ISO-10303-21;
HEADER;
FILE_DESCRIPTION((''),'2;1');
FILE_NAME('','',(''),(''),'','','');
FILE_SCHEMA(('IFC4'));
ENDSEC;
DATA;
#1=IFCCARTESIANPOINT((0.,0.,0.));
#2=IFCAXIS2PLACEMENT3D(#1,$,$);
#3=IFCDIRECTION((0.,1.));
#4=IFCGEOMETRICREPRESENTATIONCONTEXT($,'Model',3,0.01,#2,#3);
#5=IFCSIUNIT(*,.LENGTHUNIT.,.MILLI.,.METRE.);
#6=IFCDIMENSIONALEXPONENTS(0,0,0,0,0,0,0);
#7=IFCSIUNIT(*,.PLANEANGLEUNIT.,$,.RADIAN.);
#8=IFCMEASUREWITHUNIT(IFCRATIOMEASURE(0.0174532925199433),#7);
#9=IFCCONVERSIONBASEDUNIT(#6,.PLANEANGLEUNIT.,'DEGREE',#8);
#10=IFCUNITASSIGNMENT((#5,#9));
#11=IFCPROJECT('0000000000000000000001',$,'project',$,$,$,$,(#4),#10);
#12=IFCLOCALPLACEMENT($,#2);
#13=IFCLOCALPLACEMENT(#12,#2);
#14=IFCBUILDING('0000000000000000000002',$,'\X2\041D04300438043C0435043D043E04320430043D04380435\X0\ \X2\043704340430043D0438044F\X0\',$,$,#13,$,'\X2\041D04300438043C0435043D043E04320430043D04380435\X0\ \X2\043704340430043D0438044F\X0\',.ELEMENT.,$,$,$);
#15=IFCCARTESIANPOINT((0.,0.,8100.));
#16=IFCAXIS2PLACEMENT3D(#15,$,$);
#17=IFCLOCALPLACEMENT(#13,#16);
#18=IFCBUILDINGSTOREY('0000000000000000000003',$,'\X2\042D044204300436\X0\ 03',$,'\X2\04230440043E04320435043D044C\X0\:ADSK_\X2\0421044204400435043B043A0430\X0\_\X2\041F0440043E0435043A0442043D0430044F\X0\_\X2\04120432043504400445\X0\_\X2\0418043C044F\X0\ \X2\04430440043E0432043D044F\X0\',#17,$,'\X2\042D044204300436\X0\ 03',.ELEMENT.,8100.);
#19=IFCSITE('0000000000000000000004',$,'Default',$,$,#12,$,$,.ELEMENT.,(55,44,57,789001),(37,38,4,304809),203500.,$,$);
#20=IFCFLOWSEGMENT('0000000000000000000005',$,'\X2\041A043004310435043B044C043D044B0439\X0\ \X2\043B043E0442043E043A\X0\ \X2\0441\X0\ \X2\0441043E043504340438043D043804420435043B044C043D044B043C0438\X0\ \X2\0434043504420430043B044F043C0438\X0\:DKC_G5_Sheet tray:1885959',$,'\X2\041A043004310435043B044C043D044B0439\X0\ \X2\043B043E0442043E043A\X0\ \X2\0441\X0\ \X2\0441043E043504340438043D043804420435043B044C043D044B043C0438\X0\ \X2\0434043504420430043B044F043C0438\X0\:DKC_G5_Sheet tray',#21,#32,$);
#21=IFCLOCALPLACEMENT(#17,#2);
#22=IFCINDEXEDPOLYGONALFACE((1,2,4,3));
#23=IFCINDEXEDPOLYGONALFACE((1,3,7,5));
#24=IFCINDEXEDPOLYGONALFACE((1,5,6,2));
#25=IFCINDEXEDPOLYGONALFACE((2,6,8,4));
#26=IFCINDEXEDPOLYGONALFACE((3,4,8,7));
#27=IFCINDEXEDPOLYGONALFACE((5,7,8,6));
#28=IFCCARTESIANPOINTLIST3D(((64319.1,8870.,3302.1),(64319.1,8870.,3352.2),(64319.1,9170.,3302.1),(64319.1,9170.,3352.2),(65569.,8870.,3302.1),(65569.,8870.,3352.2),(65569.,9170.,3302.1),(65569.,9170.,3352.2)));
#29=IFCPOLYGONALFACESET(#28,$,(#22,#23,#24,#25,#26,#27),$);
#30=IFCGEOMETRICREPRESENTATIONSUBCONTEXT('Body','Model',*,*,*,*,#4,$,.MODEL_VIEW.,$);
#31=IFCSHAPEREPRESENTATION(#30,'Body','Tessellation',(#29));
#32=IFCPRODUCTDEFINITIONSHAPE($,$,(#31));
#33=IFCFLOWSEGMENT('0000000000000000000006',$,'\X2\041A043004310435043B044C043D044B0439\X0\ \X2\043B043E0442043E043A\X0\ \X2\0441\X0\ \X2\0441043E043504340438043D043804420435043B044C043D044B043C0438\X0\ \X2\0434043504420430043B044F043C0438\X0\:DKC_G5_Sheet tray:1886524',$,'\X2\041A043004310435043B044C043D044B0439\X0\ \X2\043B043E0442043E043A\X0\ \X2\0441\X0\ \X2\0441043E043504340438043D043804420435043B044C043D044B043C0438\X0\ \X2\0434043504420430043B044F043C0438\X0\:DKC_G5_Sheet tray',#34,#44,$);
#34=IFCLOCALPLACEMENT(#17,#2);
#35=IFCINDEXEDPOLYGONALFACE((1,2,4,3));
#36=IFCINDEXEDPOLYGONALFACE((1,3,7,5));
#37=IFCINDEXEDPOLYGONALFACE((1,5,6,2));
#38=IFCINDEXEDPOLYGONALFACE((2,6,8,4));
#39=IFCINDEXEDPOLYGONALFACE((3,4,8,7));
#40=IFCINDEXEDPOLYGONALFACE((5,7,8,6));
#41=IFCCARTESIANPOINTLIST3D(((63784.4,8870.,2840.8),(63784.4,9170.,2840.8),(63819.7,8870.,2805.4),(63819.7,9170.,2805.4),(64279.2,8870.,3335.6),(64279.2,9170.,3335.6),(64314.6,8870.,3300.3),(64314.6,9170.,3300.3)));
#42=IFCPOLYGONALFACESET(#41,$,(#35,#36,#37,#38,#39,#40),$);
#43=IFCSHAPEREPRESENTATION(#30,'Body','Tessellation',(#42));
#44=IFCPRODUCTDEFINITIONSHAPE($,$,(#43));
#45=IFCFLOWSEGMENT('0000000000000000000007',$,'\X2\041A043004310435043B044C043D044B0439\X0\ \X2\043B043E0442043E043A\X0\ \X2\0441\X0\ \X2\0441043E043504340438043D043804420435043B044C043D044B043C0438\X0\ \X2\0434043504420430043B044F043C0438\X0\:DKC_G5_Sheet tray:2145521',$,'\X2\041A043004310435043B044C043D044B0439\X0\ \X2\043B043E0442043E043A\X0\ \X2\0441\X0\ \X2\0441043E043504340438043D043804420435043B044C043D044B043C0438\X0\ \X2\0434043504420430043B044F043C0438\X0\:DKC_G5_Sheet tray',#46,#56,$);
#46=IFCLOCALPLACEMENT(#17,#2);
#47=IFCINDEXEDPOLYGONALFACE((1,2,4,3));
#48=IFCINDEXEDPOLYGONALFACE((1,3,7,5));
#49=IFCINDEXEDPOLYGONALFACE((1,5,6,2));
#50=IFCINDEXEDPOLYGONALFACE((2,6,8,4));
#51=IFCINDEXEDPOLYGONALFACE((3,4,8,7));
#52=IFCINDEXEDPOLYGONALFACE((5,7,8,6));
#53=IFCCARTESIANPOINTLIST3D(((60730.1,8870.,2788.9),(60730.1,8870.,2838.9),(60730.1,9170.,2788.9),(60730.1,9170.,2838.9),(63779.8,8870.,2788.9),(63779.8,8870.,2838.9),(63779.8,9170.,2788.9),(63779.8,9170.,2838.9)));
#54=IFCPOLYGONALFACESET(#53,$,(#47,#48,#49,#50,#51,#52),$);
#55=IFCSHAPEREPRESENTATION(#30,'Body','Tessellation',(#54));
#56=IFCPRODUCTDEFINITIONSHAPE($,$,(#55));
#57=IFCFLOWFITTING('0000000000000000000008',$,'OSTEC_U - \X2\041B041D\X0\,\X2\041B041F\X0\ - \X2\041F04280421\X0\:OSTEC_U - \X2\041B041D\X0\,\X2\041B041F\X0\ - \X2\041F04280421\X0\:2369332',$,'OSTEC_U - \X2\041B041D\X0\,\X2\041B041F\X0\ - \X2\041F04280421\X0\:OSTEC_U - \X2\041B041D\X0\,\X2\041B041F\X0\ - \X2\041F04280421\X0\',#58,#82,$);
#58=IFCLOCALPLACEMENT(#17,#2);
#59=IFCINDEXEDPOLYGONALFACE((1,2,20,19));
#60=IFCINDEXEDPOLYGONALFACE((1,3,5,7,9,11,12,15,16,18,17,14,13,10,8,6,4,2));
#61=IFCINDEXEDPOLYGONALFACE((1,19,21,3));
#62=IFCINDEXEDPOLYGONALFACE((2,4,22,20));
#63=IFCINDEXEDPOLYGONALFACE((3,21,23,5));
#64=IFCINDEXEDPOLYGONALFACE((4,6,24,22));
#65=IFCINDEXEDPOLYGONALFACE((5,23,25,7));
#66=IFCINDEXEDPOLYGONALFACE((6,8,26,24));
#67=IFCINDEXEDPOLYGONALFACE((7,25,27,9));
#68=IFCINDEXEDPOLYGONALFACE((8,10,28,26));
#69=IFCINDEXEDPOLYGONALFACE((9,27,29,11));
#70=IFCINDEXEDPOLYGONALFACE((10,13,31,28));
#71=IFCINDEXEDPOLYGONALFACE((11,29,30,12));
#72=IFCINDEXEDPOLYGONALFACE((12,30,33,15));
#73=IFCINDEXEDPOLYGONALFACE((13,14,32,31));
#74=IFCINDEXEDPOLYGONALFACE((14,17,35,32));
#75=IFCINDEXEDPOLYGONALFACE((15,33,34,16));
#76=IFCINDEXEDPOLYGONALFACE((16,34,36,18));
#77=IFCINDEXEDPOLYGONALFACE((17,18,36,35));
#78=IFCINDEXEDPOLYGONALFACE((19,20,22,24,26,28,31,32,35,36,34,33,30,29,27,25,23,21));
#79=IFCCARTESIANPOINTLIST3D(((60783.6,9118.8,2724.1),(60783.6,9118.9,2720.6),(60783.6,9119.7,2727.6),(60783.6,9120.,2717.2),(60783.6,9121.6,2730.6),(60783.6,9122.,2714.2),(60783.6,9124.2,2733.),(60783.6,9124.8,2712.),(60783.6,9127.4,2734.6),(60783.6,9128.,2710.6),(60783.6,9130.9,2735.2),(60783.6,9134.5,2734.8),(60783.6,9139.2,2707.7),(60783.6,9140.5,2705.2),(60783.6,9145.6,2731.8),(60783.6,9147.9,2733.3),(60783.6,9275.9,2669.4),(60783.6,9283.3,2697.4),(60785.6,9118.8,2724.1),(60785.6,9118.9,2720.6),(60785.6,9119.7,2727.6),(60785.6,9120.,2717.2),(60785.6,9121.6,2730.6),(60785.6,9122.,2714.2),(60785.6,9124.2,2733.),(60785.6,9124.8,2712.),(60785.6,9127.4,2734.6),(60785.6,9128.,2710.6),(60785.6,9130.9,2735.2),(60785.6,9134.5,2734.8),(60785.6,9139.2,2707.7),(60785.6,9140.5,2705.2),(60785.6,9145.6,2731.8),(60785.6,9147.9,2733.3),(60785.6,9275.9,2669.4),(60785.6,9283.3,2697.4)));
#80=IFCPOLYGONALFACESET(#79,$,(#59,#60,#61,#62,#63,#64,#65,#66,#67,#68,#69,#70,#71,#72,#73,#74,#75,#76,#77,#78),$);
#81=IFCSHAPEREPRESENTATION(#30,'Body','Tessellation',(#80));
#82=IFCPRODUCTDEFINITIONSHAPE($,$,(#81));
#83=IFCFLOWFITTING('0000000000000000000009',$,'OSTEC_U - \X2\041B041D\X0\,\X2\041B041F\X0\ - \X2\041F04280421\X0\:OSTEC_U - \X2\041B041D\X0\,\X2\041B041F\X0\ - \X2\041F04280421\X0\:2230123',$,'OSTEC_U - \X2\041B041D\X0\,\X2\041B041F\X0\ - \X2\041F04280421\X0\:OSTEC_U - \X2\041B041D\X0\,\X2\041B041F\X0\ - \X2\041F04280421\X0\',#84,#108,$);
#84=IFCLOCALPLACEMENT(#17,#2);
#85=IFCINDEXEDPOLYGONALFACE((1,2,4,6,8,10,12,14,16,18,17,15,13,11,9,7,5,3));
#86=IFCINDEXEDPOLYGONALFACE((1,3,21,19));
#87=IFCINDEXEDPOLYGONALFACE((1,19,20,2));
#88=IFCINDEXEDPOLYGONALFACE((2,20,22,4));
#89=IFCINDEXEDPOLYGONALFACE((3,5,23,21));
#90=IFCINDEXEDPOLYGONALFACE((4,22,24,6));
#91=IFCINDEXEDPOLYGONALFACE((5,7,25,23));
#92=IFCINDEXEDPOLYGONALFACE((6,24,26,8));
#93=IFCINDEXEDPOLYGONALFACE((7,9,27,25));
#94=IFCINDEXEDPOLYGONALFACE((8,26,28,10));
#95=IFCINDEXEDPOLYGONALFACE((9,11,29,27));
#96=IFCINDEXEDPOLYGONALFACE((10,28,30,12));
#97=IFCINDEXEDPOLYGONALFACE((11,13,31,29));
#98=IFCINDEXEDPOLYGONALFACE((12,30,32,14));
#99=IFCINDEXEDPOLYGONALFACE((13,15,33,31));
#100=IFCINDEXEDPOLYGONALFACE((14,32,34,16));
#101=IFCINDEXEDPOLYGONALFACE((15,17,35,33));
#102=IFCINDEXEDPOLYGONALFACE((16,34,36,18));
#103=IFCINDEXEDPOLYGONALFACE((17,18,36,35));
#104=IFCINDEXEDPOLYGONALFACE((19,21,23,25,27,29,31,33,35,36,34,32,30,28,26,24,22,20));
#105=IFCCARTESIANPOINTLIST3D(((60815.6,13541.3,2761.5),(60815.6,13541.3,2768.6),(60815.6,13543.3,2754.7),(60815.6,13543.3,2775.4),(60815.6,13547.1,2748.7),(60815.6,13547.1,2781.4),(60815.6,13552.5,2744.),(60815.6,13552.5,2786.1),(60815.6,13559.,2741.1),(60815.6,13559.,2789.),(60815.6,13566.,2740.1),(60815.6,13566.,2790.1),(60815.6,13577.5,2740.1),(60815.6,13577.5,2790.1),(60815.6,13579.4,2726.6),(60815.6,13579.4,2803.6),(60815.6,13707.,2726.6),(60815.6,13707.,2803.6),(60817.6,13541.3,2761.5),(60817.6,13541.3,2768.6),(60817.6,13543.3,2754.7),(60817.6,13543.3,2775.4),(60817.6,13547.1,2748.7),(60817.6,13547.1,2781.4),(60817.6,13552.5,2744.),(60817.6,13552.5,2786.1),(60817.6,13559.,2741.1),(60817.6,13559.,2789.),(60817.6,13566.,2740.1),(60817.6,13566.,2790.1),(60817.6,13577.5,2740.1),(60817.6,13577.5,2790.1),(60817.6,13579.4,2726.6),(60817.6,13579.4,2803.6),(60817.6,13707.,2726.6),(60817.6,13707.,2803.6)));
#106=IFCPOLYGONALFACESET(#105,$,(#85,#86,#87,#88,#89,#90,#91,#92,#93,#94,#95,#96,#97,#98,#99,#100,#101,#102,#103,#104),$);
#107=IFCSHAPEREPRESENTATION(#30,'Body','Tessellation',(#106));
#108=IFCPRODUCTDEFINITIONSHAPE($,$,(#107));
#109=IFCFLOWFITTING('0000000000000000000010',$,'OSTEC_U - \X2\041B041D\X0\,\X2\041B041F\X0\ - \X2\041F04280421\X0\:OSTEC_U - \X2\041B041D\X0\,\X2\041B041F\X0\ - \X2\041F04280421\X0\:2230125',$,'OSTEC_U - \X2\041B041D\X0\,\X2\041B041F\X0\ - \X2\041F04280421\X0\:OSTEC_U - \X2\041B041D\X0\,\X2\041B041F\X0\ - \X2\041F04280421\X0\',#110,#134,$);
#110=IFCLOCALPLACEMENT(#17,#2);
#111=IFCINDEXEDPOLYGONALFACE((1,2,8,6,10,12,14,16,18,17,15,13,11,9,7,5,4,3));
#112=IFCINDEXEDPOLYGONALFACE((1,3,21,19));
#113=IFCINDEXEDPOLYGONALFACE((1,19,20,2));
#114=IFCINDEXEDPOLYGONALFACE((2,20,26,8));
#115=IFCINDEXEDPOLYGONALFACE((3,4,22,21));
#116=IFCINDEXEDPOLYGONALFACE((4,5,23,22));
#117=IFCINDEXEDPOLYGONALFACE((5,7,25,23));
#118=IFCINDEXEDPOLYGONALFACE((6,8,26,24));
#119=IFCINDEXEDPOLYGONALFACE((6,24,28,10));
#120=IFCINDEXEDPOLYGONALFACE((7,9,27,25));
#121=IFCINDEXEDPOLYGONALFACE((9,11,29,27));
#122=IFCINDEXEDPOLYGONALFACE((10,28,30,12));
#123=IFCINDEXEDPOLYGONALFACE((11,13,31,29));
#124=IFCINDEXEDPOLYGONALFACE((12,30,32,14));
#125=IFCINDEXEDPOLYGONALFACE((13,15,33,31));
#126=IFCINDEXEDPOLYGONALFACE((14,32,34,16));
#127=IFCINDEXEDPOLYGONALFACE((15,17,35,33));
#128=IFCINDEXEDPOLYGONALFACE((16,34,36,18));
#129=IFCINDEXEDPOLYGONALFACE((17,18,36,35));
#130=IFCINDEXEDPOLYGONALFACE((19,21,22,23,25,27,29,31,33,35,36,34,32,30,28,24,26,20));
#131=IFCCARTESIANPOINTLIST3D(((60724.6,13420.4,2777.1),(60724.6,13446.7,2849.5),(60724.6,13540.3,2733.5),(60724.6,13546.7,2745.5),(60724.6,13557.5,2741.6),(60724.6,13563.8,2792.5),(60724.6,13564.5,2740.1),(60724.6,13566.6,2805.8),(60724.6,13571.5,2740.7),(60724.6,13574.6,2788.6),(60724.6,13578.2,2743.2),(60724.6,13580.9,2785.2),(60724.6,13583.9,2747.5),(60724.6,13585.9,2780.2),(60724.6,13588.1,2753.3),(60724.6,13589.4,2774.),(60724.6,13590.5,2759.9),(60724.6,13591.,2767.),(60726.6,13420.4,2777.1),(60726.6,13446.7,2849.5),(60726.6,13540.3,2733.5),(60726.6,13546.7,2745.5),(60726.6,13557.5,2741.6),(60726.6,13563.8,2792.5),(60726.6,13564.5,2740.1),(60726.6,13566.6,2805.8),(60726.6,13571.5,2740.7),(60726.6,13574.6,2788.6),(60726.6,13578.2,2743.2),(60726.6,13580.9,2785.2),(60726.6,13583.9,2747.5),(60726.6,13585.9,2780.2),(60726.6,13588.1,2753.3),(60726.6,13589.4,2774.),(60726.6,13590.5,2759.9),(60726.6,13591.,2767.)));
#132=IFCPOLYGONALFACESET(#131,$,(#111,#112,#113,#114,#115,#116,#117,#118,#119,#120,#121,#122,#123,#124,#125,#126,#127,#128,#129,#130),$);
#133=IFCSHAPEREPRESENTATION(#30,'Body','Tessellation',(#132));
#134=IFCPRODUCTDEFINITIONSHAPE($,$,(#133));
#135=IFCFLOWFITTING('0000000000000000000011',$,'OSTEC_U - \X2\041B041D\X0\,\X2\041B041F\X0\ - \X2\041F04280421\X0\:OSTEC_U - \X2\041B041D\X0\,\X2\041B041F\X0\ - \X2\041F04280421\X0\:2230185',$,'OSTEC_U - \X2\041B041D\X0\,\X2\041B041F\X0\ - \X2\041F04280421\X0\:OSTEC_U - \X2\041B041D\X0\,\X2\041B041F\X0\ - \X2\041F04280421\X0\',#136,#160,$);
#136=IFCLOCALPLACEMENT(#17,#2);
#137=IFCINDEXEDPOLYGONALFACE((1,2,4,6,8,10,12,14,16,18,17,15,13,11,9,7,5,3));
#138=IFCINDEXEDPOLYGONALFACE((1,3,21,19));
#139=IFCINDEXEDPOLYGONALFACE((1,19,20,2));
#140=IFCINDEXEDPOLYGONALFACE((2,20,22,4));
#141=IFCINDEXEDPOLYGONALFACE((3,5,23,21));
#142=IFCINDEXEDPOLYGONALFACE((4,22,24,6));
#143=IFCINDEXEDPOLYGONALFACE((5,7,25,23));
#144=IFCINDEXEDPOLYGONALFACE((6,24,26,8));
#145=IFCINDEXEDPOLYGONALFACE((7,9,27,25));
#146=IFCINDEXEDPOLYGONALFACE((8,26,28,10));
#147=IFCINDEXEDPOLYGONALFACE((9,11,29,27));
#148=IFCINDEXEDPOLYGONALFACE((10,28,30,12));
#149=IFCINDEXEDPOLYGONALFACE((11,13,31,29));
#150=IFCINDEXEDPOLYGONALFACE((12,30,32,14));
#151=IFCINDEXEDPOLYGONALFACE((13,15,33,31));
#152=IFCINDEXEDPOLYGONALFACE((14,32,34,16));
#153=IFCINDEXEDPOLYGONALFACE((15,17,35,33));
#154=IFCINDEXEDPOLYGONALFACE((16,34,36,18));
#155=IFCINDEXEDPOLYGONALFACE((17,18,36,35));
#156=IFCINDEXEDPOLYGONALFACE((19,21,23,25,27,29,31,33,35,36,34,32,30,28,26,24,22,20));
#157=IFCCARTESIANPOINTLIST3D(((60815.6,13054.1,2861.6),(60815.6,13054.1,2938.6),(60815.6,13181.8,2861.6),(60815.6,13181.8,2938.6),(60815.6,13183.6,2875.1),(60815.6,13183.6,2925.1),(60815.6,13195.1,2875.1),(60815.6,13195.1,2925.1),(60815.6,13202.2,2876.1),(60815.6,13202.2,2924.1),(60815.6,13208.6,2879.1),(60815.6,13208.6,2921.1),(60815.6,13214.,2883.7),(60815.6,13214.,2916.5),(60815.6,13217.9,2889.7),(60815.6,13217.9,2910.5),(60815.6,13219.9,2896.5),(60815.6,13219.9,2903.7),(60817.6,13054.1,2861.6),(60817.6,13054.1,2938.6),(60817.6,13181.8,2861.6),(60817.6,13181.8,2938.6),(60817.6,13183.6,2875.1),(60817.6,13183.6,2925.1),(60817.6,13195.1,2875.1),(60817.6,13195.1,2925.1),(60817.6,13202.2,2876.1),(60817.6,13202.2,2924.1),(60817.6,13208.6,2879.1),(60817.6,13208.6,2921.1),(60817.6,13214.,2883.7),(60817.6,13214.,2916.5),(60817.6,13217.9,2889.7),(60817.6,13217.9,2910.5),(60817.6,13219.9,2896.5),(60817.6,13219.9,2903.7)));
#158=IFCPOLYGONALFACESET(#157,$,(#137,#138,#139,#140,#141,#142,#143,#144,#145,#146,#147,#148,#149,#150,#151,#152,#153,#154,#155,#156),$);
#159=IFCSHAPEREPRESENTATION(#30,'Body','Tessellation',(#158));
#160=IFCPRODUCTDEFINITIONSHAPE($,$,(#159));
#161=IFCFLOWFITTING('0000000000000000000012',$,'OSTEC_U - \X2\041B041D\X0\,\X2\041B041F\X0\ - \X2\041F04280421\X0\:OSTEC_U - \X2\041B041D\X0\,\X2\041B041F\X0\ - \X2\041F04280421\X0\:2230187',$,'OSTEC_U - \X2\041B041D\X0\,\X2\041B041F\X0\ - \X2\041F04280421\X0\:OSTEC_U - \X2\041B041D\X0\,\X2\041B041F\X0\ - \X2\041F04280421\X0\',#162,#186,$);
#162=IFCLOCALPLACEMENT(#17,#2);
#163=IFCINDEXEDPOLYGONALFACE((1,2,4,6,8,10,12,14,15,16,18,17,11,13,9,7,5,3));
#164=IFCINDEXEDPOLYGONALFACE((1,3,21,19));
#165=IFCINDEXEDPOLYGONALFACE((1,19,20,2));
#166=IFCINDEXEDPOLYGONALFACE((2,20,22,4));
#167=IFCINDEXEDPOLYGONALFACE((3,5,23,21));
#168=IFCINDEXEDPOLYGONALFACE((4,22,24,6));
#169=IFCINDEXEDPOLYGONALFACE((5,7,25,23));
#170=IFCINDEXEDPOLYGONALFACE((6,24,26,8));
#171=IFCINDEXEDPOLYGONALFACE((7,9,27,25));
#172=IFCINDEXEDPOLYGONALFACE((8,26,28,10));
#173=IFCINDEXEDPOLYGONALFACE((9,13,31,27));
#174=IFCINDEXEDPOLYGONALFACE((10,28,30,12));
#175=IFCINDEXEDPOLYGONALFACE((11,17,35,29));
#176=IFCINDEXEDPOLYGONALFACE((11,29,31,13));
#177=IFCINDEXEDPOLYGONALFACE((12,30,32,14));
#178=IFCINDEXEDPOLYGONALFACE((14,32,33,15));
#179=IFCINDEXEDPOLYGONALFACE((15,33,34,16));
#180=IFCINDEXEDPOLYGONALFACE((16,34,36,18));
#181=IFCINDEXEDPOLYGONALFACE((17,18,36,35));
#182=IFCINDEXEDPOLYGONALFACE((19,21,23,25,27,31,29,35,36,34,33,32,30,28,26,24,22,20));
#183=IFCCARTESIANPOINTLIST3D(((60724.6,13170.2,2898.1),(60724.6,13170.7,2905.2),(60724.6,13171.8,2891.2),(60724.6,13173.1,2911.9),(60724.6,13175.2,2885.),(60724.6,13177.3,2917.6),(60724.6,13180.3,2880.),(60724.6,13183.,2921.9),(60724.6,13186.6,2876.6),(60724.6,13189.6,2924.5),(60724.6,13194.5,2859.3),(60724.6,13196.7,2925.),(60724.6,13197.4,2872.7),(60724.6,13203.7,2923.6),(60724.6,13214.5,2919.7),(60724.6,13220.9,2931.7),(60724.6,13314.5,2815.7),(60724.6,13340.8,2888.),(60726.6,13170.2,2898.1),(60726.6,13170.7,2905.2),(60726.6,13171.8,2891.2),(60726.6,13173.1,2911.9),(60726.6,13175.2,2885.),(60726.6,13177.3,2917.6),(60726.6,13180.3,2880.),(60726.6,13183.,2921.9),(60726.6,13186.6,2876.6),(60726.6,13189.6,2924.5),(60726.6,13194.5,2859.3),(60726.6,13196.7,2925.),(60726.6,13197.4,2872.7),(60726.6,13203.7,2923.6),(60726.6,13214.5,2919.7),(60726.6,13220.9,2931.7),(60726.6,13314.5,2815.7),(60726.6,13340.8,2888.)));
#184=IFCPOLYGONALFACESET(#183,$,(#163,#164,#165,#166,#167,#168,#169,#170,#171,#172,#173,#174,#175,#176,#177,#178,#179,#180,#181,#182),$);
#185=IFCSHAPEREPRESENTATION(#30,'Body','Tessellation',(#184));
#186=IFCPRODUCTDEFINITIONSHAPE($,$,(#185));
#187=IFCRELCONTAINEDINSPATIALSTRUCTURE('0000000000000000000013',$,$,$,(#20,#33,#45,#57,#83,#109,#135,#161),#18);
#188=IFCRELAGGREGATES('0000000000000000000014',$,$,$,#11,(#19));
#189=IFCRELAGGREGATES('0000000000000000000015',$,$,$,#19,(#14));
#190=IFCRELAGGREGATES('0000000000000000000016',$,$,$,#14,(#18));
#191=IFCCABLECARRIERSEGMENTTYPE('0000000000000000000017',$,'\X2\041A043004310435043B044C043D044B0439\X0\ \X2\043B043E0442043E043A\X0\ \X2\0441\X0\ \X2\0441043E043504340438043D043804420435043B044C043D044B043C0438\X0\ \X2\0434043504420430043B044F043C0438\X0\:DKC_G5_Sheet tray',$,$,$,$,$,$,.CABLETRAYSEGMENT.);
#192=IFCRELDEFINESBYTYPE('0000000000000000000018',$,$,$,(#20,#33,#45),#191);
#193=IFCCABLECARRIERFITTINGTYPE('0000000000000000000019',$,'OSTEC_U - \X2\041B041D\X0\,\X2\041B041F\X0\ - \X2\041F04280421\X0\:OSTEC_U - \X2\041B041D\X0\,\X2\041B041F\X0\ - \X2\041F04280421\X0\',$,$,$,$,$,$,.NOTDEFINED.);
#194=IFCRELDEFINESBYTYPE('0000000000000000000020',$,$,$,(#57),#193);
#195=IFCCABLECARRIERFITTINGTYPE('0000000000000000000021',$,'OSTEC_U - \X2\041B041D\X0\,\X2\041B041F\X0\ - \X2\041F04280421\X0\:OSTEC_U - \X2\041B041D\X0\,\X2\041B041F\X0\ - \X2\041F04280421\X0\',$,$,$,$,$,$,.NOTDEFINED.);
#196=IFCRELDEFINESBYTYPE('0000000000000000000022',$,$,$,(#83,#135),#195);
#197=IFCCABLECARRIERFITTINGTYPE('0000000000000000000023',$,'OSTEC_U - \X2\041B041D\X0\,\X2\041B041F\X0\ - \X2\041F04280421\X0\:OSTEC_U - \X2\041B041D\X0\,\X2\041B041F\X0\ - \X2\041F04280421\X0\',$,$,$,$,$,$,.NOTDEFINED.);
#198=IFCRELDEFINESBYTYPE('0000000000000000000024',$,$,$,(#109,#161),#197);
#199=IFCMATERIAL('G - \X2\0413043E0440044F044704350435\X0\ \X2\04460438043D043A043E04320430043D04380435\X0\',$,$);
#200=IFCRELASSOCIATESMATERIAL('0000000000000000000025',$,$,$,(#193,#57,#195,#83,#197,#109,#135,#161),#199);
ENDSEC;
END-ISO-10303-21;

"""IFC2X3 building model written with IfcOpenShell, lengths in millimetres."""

from ifc_helpers import new_model, entity, si_unit, converted_unit, direction, frame, frame_2d, origin, origin_2d_with_axis, place, context, subcontext, project, spatial, polyline, circle_curve, parameter, trimmed, segment, composite_curve, rectangle, outline, extrude, source, transform, mapped, material, type_object, type_shapes, element, save


model = new_model("IFC2X3")

# Units and contexts
model_context = context("Model", 3, precision=0.01, world=origin(), true_north=direction((0.0, 1.0)))
body_context = subcontext(model_context, "Body", "Model", "MODEL_VIEW")
ifc_project = project(units=[si_unit("LENGTHUNIT", "METRE", prefix="MILLI"), converted_unit("PLANEANGLEUNIT", "DEGREE", entity("IfcRatioMeasure", 0.0174532925199433), si_unit("PLANEANGLEUNIT", "RADIAN"), dimensions=[0, 0, 0, 0, 0, 0, 0])], contexts=[model_context])

# Site, building, storey
site_placement = place(None, origin())
site = spatial("IfcSite", under=ifc_project, at=site_placement, Name="Default", CompositionType="ELEMENT", RefLatitude=(55, 44, 57, 789001), RefLongitude=(37, 38, 4, 304809), RefElevation=203500.0)
building_placement = place(site_placement, origin())
building = spatial("IfcBuilding", under=site, at=building_placement, Name="Наименование здания", LongName="Наименование здания", CompositionType="ELEMENT")
storey_placement = place(building_placement, frame((0.0, 0.0, 8100.0)))
storey = spatial("IfcBuildingStorey", under=building, at=storey_placement, Name="Этаж 03", ObjectType="Уровень:ADSK_Стрелка_Проектная_Вверх_Имя уровня", LongName="Этаж 03", CompositionType="ELEMENT", Elevation=8100.0)

# Flow segments
cable_carrier_segment_type = type_object("IfcCableCarrierSegmentType", Name="Кабельный лоток с соединительными деталями:DKC_G5_Sheet tray", PredefinedType="CABLETRAYSEGMENT")
flow_segment_1_placement = place(storey_placement, frame((64319.1, 8870.0, 3302.2)))
element("IfcFlowSegment", 1, at=flow_segment_1_placement, inside=storey, type_object=cable_carrier_segment_type, Name="Кабельный лоток с соединительными деталями:DKC_G5_Sheet tray:1885959", ObjectType="Кабельный лоток с соединительными деталями:DKC_G5_Sheet tray", context=body_context, shape_type="SweptSolid", body=[
    extrude(rectangle(XDim=1249.9, YDim=300.0, at=origin_2d_with_axis()), frame((624.9, 150.0, 0.0), z_axis=(0.0, 0.0, 1.0), x_axis=(-1.0, 0.0, 0.0)), (0.0, 0.0, 1.0), 50.0),
])
flow_segment_2_placement = place(storey_placement, frame((63784.4, 8870.0, 2805.4)))
element("IfcFlowSegment", 2, at=flow_segment_2_placement, inside=storey, type_object=cable_carrier_segment_type, Name="Кабельный лоток с соединительными деталями:DKC_G5_Sheet tray:1886524", ObjectType="Кабельный лоток с соединительными деталями:DKC_G5_Sheet tray", context=body_context, shape_type="SweptSolid", body=[
    extrude(rectangle(XDim=50.0, YDim=300.0, at=origin_2d_with_axis()), frame((17.7, 150.0, 17.7), z_axis=(0.707107, 0.0, 0.707107), x_axis=(-0.707107, 0.0, 0.707107)), (0.0, 0.0, 1.0), 699.8),
])
flow_segment_3_placement = place(storey_placement, frame((60730.1, 8870.0, 2788.9)))
element("IfcFlowSegment", 3, at=flow_segment_3_placement, inside=storey, type_object=cable_carrier_segment_type, Name="Кабельный лоток с соединительными деталями:DKC_G5_Sheet tray:2145521", ObjectType="Кабельный лоток с соединительными деталями:DKC_G5_Sheet tray", context=body_context, shape_type="SweptSolid", body=[
    extrude(rectangle(XDim=3049.7, YDim=300.0, at=origin_2d_with_axis()), frame((1524.9, 150.0, 0.0)), (0.0, 0.0, 1.0), 50.0),
])

# Flow fittings
ifc_material_1 = material(Name="G - Горячее цинкование")
cable_carrier_fitting_type_1 = type_object("IfcCableCarrierFittingType", Name="OSTEC_U - ЛН,ЛП - ПШС:OSTEC_U - ЛН,ЛП - ПШС", PredefinedType="NOTDEFINED", material=ifc_material_1)
shared_shape_1 = source(origin(), body_context, "Body", "SweptSolid", [
    extrude(outline(composite_curve([segment(trimmed(circle_curve(frame_2d((-44.6, 0.0), x_axis=(1.0, 0.0)), 12.5), [parameter(90.0)], [parameter(270.0)], True, "PARAMETER"), True, "CONTINUOUS"), segment(polyline([(-44.6, -12.5), (-33.1, -12.5)]), True, "CONTINUOUS"), segment(polyline([(-33.1, -12.5), (-31.2, -14.5)]), True, "CONTINUOUS"), segment(polyline([(-31.2, -14.5), (108.9, -14.5)]), True, "CONTINUOUS"), segment(polyline([(108.9, -14.5), (108.9, 14.5)]), True, "CONTINUOUS"), segment(polyline([(108.9, 14.5), (-31.2, 14.5)]), True, "CONTINUOUS"), segment(polyline([(-31.2, 14.5), (-33.1, 12.5)]), True, "CONTINUOUS"), segment(polyline([(-33.1, 12.5), (-44.6, 12.5)]), True, "CONTINUOUS")], self_intersect=False)), frame((44.6, 0.0, 0.0)), (0.0, 0.0, 1.0), 2.0),
])
type_shapes(cable_carrier_fitting_type_1, [shared_shape_1])
for number, where, z_axis, x_axis, name in (
    (4, (60783.6, 9131.2, 2722.7), (1.0, 0.0, 0.0), (0.0, 0.966668, -0.256034), "OSTEC_U - ЛН,ЛП - ПШС:OSTEC_U - ЛН,ЛП - ПШС:2369332"),
):
    element("IfcFlowFitting", number, at=place(storey_placement, frame(where, z_axis=z_axis, x_axis=x_axis)), inside=storey, type_object=cable_carrier_fitting_type_1, material=ifc_material_1, Name=name, ObjectType="OSTEC_U - ЛН,ЛП - ПШС:OSTEC_U - ЛН,ЛП - ПШС", context=body_context, shape_type="MappedRepresentation", body=[
        mapped(shared_shape_1, transform((0.0, 0.0, 0.0), scale=1.0)),
    ])
cable_carrier_fitting_type_2 = type_object("IfcCableCarrierFittingType", Name="OSTEC_U - ЛН,ЛП - ПШС:OSTEC_U - ЛН,ЛП - ПШС", PredefinedType="NOTDEFINED", material=ifc_material_1)
shared_shape_2 = source(origin(), body_context, "Body", "SweptSolid", [
    extrude(outline(composite_curve([segment(trimmed(circle_curve(frame_2d((-41.5, 0.0), x_axis=(1.0, 0.0)), 25.0), [parameter(90.0)], [parameter(270.0)], True, "PARAMETER"), True, "CONTINUOUS"), segment(polyline([(-41.5, -25.0), (-30.0, -25.0)]), True, "CONTINUOUS"), segment(polyline([(-30.0, -25.0), (-28.1, -38.5)]), True, "CONTINUOUS"), segment(polyline([(-28.1, -38.5), (99.5, -38.5)]), True, "CONTINUOUS"), segment(polyline([(99.5, -38.5), (99.5, 38.5)]), True, "CONTINUOUS"), segment(polyline([(99.5, 38.5), (-28.1, 38.5)]), True, "CONTINUOUS"), segment(polyline([(-28.1, 38.5), (-30.0, 25.0)]), True, "CONTINUOUS"), segment(polyline([(-30.0, 25.0), (-41.5, 25.0)]), True, "CONTINUOUS")], self_intersect=False)), frame((41.5, 0.0, 0.0), z_axis=(0.0, 0.0, -1.0), x_axis=(1.0, 0.0, 0.0)), (0.0, 0.0, -1.0), 2.0),
])
type_shapes(cable_carrier_fitting_type_2, [shared_shape_2])
flow_fitting_1_placement = place(storey_placement, frame((60815.6, 13566.0, 2765.1), z_axis=(1.0, 0.0, 0.0), x_axis=(0.0, 1.0, 0.000034)))
element("IfcFlowFitting", 5, at=flow_fitting_1_placement, inside=storey, type_object=cable_carrier_fitting_type_2, material=ifc_material_1, Name="OSTEC_U - ЛН,ЛП - ПШС:OSTEC_U - ЛН,ЛП - ПШС:2230123", ObjectType="OSTEC_U - ЛН,ЛП - ПШС:OSTEC_U - ЛН,ЛП - ПШС", context=body_context, shape_type="MappedRepresentation", body=[
    mapped(shared_shape_2, transform((0.0, 0.0, 0.0), scale=1.0)),
])
cable_carrier_fitting_type_3 = type_object("IfcCableCarrierFittingType", Name="OSTEC_U - ЛН,ЛП - ПШС:OSTEC_U - ЛН,ЛП - ПШС", PredefinedType="NOTDEFINED", material=ifc_material_1)
type_shapes(cable_carrier_fitting_type_3, [shared_shape_2])
flow_fitting_2_placement = place(storey_placement, frame((60726.7, 13566.0, 2765.1), z_axis=(-1.0, 0.0, 0.0), x_axis=(0.0, -0.939662, 0.342104)))
element("IfcFlowFitting", 6, at=flow_fitting_2_placement, inside=storey, type_object=cable_carrier_fitting_type_3, material=ifc_material_1, Name="OSTEC_U - ЛН,ЛП - ПШС:OSTEC_U - ЛН,ЛП - ПШС:2230125", ObjectType="OSTEC_U - ЛН,ЛП - ПШС:OSTEC_U - ЛН,ЛП - ПШС", context=body_context, shape_type="MappedRepresentation", body=[
    mapped(shared_shape_2, transform((0.0, 0.0, 0.0), scale=1.0)),
])
flow_fitting_3_placement = place(storey_placement, frame((60815.6, 13195.1, 2900.1), z_axis=(1.0, 0.0, 0.0), x_axis=(0.0, -1.0, 0.0)))
element("IfcFlowFitting", 7, at=flow_fitting_3_placement, inside=storey, type_object=cable_carrier_fitting_type_2, material=ifc_material_1, Name="OSTEC_U - ЛН,ЛП - ПШС:OSTEC_U - ЛН,ЛП - ПШС:2230185", ObjectType="OSTEC_U - ЛН,ЛП - ПШС:OSTEC_U - ЛН,ЛП - ПШС", context=body_context, shape_type="MappedRepresentation", body=[
    mapped(shared_shape_2, transform((0.0, 0.0, 0.0), scale=1.0)),
])
for number, where, z_axis, x_axis, name in (
    (8, (60726.7, 13195.1, 2900.1), (-1.0, 0.0, 0.0), (0.0, 0.939662, -0.342104), "OSTEC_U - ЛН,ЛП - ПШС:OSTEC_U - ЛН,ЛП - ПШС:2230187"),
):
    element("IfcFlowFitting", number, at=place(storey_placement, frame(where, z_axis=z_axis, x_axis=x_axis)), inside=storey, type_object=cable_carrier_fitting_type_3, material=ifc_material_1, Name=name, ObjectType="OSTEC_U - ЛН,ЛП - ПШС:OSTEC_U - ЛН,ЛП - ПШС", context=body_context, shape_type="MappedRepresentation", body=[
        mapped(shared_shape_2, transform((0.0, 0.0, 0.0), scale=1.0)),
    ])

save(model, "model.ifc")
